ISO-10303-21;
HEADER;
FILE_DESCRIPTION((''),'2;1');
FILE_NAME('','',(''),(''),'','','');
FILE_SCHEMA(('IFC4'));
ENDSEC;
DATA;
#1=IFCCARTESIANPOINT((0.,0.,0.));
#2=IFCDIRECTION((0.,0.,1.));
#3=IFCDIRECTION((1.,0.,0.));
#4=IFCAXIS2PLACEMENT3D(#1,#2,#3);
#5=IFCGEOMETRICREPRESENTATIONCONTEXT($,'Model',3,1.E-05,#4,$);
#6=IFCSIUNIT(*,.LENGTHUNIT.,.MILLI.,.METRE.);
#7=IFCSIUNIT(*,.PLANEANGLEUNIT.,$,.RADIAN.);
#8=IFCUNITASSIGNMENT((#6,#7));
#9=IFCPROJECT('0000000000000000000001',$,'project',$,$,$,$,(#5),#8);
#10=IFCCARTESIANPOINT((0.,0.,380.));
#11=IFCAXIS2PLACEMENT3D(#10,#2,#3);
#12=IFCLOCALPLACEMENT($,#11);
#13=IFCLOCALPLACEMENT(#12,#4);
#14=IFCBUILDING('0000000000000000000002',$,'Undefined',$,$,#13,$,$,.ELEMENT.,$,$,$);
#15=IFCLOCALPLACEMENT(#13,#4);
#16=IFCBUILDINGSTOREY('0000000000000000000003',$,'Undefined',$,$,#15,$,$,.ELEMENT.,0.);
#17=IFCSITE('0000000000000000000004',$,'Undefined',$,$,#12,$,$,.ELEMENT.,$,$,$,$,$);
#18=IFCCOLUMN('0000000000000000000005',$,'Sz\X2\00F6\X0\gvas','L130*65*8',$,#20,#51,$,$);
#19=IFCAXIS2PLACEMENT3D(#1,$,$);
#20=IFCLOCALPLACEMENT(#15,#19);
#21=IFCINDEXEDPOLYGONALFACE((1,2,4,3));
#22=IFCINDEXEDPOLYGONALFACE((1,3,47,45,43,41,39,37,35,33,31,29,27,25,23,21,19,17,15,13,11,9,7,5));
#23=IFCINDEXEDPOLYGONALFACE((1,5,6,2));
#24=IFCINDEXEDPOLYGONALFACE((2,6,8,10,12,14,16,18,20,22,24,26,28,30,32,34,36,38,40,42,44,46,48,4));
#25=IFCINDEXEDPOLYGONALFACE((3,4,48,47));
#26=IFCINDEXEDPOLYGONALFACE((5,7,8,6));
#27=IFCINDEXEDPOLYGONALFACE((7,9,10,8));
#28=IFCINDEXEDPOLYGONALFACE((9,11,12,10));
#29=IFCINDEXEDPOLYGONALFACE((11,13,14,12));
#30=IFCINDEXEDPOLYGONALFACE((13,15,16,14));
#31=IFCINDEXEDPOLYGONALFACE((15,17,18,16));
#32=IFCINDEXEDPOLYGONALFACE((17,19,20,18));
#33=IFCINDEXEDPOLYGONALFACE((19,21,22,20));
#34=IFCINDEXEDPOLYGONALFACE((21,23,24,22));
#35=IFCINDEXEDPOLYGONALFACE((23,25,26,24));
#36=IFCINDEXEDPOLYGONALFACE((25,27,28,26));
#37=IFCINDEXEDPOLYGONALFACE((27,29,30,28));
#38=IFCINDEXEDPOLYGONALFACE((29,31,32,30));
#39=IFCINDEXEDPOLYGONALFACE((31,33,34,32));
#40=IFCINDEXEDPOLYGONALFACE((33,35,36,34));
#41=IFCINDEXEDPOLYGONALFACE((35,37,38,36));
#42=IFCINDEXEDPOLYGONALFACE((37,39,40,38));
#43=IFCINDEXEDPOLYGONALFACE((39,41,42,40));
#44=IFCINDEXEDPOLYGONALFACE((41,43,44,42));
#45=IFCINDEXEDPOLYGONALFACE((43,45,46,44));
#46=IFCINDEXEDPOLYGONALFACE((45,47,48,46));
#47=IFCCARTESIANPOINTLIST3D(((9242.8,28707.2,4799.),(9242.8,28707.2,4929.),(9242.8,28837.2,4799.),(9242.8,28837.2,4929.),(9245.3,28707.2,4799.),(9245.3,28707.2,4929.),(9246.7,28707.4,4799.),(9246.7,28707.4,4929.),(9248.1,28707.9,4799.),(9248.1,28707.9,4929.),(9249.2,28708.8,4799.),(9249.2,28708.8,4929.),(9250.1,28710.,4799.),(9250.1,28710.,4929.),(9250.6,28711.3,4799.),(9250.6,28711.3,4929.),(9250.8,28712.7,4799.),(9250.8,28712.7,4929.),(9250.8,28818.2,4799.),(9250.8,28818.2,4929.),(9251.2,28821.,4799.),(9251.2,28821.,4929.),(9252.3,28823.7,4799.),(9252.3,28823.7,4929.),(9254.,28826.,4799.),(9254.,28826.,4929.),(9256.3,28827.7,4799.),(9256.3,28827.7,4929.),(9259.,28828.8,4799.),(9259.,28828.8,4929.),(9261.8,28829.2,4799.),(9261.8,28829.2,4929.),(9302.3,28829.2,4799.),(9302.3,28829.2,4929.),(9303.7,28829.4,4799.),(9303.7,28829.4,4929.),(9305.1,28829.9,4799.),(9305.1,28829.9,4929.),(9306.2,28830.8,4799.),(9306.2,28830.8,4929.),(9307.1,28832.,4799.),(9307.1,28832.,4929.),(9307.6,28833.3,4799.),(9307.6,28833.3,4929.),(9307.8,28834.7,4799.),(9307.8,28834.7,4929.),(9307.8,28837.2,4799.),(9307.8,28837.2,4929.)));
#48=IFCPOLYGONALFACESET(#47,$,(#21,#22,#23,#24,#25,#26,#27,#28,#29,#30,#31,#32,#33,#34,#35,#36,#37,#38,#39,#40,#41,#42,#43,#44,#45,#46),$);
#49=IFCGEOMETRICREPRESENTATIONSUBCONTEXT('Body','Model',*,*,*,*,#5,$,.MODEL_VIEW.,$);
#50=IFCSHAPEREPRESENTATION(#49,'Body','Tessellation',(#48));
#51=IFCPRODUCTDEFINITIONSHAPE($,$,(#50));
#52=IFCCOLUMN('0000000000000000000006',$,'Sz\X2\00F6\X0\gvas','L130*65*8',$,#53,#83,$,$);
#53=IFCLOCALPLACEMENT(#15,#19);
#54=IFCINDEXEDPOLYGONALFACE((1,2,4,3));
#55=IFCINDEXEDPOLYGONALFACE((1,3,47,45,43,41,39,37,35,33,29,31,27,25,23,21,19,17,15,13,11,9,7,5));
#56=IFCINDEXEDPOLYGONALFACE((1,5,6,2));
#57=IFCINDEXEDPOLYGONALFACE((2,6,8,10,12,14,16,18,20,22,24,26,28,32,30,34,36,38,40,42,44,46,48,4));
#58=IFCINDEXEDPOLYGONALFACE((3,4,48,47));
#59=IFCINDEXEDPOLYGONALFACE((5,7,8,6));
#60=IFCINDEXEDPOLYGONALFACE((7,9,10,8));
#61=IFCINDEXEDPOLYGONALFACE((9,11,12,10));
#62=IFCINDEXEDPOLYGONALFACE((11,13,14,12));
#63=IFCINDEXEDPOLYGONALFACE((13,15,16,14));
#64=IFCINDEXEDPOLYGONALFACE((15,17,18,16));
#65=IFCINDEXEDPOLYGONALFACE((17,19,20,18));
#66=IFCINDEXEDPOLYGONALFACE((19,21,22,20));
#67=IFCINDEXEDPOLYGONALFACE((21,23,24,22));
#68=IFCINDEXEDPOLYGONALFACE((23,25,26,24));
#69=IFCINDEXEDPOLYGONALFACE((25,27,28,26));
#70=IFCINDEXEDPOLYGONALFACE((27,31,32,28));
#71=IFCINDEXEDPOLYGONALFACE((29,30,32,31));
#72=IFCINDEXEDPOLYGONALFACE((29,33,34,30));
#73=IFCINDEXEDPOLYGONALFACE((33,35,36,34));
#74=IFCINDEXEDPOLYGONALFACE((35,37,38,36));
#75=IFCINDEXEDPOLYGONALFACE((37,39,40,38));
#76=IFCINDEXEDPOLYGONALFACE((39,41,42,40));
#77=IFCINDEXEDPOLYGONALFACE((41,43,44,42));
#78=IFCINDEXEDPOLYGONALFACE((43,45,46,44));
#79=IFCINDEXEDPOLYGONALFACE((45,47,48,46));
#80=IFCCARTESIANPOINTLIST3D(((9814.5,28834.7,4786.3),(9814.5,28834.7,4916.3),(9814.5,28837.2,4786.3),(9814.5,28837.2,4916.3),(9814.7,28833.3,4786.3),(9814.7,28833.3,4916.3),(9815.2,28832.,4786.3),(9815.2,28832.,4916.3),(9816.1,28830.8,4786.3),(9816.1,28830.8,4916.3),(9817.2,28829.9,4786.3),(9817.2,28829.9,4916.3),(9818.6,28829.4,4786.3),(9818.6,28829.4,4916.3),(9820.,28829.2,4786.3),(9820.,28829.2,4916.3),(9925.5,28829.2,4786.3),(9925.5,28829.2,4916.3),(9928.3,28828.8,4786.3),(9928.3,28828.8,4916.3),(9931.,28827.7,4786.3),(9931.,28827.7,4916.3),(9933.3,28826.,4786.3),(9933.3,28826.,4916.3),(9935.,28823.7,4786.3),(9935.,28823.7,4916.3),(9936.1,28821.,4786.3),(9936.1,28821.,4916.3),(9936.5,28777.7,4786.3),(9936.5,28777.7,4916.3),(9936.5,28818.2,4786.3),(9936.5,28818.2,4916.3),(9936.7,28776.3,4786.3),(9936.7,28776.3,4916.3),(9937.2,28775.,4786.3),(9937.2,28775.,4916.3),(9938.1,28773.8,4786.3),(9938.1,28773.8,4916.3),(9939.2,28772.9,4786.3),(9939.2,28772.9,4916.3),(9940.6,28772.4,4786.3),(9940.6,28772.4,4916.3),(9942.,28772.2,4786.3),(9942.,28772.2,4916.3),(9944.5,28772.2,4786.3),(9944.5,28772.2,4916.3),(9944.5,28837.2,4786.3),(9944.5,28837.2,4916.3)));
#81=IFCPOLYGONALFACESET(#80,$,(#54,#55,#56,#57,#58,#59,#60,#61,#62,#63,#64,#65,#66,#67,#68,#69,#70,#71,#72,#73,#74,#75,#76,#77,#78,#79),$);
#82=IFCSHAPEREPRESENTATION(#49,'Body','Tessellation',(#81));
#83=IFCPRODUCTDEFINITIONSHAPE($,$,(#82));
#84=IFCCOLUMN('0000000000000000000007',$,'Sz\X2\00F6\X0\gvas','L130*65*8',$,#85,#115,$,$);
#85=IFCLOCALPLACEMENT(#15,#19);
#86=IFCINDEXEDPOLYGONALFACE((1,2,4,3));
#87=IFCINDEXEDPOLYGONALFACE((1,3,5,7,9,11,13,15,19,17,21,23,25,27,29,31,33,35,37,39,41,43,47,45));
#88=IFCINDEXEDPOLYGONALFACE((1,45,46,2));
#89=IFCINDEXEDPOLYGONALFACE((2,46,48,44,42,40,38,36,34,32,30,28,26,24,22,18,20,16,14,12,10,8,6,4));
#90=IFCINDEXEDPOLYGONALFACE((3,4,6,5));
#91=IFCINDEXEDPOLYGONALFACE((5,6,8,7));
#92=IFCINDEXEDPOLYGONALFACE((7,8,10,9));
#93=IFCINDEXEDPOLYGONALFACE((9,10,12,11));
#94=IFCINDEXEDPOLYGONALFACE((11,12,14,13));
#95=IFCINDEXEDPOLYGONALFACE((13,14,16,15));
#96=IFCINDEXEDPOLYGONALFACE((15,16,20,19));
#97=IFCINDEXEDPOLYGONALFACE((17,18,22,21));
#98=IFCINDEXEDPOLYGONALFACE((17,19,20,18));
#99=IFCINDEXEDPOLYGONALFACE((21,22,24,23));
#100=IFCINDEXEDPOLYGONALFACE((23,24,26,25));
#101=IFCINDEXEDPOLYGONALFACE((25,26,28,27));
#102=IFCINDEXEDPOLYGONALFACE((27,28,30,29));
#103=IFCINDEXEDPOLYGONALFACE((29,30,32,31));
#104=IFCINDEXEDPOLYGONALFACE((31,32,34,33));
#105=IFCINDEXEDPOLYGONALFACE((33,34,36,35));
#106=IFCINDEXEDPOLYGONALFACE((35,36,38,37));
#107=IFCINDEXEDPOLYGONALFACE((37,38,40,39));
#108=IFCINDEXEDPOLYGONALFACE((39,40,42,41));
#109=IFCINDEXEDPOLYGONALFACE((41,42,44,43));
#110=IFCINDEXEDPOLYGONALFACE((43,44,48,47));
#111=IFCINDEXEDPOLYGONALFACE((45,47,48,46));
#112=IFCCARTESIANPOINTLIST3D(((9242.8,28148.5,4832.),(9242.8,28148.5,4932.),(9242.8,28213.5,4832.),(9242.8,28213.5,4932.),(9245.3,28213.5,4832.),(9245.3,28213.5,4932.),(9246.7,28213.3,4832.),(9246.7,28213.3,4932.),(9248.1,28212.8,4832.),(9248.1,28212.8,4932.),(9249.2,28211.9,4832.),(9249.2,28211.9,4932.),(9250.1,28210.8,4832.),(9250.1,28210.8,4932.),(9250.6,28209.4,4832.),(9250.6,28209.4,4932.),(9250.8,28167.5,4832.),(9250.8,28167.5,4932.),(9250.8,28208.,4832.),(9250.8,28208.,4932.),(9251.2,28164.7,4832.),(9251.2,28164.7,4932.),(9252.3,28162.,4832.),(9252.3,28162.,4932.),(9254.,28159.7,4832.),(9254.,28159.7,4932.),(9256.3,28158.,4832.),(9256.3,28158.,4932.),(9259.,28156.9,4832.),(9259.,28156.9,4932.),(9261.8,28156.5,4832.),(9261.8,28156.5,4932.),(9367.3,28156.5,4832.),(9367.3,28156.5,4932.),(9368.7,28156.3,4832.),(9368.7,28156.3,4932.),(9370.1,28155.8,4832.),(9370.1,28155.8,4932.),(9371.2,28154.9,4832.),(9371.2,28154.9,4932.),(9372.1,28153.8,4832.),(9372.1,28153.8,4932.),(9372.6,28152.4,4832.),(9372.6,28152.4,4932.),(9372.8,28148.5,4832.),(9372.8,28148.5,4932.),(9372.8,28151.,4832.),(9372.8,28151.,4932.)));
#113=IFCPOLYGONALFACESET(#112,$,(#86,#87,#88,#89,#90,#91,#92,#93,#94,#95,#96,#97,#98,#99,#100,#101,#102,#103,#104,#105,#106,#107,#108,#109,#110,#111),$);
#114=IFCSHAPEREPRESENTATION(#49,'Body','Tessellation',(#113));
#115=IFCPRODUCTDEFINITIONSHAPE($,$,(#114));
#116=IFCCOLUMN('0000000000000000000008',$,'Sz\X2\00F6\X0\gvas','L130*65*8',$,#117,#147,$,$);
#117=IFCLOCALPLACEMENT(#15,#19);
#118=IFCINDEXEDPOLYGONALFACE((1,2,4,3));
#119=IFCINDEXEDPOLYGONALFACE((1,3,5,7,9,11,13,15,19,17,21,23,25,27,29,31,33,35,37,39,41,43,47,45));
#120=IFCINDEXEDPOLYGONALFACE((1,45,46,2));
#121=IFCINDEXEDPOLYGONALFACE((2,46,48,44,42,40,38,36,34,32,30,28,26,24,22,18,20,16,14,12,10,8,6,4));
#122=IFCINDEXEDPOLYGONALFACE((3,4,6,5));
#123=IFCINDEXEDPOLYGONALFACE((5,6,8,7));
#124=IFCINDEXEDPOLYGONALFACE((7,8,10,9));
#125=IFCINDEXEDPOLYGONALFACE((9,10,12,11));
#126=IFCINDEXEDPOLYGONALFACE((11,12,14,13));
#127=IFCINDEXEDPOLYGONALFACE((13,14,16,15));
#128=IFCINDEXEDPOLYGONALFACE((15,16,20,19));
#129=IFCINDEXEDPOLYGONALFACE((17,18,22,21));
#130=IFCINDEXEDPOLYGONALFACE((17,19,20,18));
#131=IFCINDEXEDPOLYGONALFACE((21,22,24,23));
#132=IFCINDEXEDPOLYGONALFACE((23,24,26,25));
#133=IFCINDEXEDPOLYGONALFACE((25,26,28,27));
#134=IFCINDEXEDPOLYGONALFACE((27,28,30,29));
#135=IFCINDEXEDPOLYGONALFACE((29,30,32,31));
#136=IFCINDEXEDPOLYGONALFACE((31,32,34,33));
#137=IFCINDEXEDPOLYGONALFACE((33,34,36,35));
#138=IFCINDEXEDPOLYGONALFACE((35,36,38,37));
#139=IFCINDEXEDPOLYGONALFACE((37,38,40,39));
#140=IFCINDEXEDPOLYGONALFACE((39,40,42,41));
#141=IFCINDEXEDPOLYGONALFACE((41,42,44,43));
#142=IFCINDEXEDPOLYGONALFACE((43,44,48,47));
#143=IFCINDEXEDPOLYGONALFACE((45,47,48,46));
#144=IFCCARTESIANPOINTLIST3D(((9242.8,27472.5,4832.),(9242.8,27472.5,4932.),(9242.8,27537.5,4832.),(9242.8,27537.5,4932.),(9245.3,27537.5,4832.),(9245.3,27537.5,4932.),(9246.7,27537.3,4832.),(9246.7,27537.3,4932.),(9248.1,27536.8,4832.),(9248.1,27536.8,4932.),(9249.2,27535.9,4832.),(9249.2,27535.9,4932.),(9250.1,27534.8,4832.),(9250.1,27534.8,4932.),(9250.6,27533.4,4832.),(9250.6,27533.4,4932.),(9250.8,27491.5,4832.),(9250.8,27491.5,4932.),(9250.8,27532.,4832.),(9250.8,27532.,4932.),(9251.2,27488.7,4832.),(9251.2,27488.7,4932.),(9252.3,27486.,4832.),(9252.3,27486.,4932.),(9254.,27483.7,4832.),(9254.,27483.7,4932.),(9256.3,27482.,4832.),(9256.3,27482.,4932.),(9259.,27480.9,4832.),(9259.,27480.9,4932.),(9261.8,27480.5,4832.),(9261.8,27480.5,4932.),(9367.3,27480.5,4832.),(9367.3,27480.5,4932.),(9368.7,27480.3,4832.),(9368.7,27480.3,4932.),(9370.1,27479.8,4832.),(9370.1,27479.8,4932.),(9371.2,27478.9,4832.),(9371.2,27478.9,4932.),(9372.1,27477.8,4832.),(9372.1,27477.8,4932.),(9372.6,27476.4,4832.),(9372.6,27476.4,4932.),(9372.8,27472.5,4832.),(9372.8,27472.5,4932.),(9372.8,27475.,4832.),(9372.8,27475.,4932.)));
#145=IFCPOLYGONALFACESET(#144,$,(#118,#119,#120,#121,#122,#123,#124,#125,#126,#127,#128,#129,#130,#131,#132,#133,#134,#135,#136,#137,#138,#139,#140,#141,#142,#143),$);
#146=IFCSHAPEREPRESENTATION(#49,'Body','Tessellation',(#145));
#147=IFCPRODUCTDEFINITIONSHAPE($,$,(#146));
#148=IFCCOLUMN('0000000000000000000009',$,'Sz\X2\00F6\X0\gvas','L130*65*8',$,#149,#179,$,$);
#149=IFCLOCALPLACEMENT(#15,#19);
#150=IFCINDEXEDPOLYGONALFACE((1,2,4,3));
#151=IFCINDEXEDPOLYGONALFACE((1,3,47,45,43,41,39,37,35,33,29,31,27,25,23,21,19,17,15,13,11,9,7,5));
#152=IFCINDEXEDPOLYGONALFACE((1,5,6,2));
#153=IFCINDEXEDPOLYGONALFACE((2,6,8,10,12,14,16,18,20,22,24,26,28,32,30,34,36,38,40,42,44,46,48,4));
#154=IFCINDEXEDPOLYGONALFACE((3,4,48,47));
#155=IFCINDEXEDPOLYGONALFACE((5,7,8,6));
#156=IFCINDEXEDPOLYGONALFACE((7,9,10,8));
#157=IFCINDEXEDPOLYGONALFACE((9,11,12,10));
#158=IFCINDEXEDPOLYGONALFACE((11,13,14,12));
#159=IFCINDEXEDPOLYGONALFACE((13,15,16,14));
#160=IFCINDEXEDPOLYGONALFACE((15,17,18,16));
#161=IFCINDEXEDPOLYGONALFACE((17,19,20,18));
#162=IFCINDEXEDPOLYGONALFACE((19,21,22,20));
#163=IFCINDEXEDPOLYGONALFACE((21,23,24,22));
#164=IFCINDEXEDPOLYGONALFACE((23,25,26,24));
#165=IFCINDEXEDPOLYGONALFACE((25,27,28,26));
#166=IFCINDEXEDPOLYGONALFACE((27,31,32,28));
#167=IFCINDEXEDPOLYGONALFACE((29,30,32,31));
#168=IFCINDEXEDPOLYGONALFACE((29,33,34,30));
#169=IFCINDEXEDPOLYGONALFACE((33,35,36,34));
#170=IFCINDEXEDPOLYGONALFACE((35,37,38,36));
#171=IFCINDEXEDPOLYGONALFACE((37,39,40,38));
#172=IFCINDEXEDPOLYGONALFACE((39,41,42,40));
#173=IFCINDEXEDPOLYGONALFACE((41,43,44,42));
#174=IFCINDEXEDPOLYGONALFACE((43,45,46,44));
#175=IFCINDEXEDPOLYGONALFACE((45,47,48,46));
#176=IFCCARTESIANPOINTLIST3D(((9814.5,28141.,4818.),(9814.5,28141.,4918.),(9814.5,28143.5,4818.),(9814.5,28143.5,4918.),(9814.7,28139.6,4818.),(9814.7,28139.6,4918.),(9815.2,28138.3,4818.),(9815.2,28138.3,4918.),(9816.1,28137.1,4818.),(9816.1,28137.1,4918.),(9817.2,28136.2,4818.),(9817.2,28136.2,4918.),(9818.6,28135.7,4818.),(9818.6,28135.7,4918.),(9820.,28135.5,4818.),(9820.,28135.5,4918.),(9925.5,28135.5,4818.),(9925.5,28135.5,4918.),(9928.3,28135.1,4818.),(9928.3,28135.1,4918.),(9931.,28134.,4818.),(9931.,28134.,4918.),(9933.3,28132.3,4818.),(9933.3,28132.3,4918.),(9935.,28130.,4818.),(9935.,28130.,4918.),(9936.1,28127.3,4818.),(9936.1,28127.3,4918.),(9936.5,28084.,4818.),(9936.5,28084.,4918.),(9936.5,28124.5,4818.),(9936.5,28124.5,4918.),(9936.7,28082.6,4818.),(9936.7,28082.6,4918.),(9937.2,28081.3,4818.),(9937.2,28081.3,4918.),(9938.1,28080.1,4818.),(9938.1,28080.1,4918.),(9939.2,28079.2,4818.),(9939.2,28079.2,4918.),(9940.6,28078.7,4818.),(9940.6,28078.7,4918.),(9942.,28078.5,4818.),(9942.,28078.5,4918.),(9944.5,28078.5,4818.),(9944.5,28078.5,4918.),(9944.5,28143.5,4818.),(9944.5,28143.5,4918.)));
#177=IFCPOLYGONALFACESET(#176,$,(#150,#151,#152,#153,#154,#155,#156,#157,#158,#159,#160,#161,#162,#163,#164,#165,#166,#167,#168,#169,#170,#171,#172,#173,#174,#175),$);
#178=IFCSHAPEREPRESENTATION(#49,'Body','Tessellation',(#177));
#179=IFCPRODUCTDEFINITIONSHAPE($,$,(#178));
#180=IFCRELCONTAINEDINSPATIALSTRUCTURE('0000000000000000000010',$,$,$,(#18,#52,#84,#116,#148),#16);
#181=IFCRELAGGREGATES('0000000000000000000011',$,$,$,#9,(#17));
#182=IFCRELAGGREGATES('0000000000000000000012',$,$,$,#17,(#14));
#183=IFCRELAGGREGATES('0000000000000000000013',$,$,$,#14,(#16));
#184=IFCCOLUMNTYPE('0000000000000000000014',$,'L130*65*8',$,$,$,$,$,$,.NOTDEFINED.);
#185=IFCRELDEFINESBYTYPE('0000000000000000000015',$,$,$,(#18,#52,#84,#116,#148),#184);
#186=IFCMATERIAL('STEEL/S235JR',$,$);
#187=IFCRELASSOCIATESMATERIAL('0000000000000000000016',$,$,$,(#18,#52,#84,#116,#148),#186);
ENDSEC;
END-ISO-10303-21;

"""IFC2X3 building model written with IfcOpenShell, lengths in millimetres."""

from ifc_helpers import new_model, si_unit, frame, origin_with_axes, origin_2d_with_axis, place, context, subcontext, project, spatial, l_section, extrude, material, type_object, element, save


model = new_model("IFC2X3")

# Units and contexts
model_context = context("Model", 3, precision=1e-05, world=origin_with_axes())
body_context = subcontext(model_context, "Body", "Model", "MODEL_VIEW")
ifc_project = project(units=[si_unit("LENGTHUNIT", "METRE", prefix="MILLI"), si_unit("PLANEANGLEUNIT", "RADIAN")], contexts=[model_context])

# Site, building, storey
site_placement = place(None, frame((0.0, 0.0, 380.0), z_axis=(0.0, 0.0, 1.0), x_axis=(1.0, 0.0, 0.0)))
site = spatial("IfcSite", under=ifc_project, at=site_placement, Name="Undefined", CompositionType="ELEMENT")
building_placement = place(site_placement, origin_with_axes())
building = spatial("IfcBuilding", under=site, at=building_placement, Name="Undefined", CompositionType="ELEMENT")
storey_placement = place(building_placement, origin_with_axes())
storey = spatial("IfcBuildingStorey", under=building, at=storey_placement, Name="Undefined", CompositionType="ELEMENT", Elevation=0.0)

# Columns
ifc_material = material(Name="STEEL/S235JR")
column_type_1 = type_object("IfcColumnType", Name="L130*65*8", PredefinedType="NOTDEFINED")
for number, where, z_axis, x_axis, name in (
    (1, (9275.3, 28772.2, 4799.0), (0.0, 0.0, 1.0), (0.0, -1.0, 0.0), "Szögvas"),
    (2, (9879.5, 28804.7, 4786.2), (0.0, 0.0, 1.0), (-1.0, 0.0, 0.0), "Szögvas"),
):
    element("IfcColumn", number, at=place(storey_placement, frame(where, z_axis=z_axis, x_axis=x_axis)), inside=storey, type_object=column_type_1, material=ifc_material, Name=name, Description="L130*65*8", context=body_context, shape_type="SweptSolid", body=[
        extrude(l_section(Depth=130.0, Width=65.0, Thickness=8.0, FilletRadius=11.0, EdgeRadius=5.5, at=origin_2d_with_axis()), frame((0.0, 0.0, 130.0), z_axis=(0.0, 0.0, -1.0), x_axis=(0.0, 1.0, 0.0)), (0.0, 0.0, 1.0), 130.0),
    ])
column_1_placement = place(storey_placement, frame((9307.8, 28181.0, 4831.9), z_axis=(0.0, 0.0, 1.0), x_axis=(1.0, 0.0, 0.0)))
element("IfcColumn", 3, at=column_1_placement, inside=storey, type_object=column_type_1, material=ifc_material, Name="Szögvas", Description="L130*65*8", context=body_context, shape_type="SweptSolid", body=[
    extrude(l_section(Depth=130.0, Width=65.0, Thickness=8.0, FilletRadius=11.0, EdgeRadius=5.5, at=origin_2d_with_axis()), frame((0.0, 0.0, 100.0), z_axis=(0.0, 0.0, -1.0), x_axis=(0.0, 1.0, 0.0)), (0.0, 0.0, 1.0), 100.0),
])
column_2_placement = place(storey_placement, frame((9307.8, 27505.0, 4832.0), z_axis=(0.0, 0.0, 1.0), x_axis=(1.0, 0.0, 0.0)))
element("IfcColumn", 4, at=column_2_placement, inside=storey, type_object=column_type_1, material=ifc_material, Name="Szögvas", Description="L130*65*8", context=body_context, shape_type="SweptSolid", body=[
    extrude(l_section(Depth=130.0, Width=65.0, Thickness=8.0, FilletRadius=11.0, EdgeRadius=5.5, at=origin_2d_with_axis()), frame((0.0, 0.0, 100.0), z_axis=(0.0, 0.0, -1.0), x_axis=(0.0, 1.0, 0.0)), (0.0, 0.0, 1.0), 100.0),
])
column_3_placement = place(storey_placement, frame((9879.5, 28111.0, 4818.0), z_axis=(0.0, 0.0, 1.0), x_axis=(-1.0, 0.0, 0.0)))
element("IfcColumn", 5, at=column_3_placement, inside=storey, type_object=column_type_1, material=ifc_material, Name="Szögvas", Description="L130*65*8", context=body_context, shape_type="SweptSolid", body=[
    extrude(l_section(Depth=130.0, Width=65.0, Thickness=8.0, FilletRadius=11.0, EdgeRadius=5.5, at=origin_2d_with_axis()), frame((0.0, 0.0, 100.0), z_axis=(0.0, 0.0, -1.0), x_axis=(0.0, 1.0, 0.0)), (0.0, 0.0, 1.0), 100.0),
])

save(model, "model.ifc")
